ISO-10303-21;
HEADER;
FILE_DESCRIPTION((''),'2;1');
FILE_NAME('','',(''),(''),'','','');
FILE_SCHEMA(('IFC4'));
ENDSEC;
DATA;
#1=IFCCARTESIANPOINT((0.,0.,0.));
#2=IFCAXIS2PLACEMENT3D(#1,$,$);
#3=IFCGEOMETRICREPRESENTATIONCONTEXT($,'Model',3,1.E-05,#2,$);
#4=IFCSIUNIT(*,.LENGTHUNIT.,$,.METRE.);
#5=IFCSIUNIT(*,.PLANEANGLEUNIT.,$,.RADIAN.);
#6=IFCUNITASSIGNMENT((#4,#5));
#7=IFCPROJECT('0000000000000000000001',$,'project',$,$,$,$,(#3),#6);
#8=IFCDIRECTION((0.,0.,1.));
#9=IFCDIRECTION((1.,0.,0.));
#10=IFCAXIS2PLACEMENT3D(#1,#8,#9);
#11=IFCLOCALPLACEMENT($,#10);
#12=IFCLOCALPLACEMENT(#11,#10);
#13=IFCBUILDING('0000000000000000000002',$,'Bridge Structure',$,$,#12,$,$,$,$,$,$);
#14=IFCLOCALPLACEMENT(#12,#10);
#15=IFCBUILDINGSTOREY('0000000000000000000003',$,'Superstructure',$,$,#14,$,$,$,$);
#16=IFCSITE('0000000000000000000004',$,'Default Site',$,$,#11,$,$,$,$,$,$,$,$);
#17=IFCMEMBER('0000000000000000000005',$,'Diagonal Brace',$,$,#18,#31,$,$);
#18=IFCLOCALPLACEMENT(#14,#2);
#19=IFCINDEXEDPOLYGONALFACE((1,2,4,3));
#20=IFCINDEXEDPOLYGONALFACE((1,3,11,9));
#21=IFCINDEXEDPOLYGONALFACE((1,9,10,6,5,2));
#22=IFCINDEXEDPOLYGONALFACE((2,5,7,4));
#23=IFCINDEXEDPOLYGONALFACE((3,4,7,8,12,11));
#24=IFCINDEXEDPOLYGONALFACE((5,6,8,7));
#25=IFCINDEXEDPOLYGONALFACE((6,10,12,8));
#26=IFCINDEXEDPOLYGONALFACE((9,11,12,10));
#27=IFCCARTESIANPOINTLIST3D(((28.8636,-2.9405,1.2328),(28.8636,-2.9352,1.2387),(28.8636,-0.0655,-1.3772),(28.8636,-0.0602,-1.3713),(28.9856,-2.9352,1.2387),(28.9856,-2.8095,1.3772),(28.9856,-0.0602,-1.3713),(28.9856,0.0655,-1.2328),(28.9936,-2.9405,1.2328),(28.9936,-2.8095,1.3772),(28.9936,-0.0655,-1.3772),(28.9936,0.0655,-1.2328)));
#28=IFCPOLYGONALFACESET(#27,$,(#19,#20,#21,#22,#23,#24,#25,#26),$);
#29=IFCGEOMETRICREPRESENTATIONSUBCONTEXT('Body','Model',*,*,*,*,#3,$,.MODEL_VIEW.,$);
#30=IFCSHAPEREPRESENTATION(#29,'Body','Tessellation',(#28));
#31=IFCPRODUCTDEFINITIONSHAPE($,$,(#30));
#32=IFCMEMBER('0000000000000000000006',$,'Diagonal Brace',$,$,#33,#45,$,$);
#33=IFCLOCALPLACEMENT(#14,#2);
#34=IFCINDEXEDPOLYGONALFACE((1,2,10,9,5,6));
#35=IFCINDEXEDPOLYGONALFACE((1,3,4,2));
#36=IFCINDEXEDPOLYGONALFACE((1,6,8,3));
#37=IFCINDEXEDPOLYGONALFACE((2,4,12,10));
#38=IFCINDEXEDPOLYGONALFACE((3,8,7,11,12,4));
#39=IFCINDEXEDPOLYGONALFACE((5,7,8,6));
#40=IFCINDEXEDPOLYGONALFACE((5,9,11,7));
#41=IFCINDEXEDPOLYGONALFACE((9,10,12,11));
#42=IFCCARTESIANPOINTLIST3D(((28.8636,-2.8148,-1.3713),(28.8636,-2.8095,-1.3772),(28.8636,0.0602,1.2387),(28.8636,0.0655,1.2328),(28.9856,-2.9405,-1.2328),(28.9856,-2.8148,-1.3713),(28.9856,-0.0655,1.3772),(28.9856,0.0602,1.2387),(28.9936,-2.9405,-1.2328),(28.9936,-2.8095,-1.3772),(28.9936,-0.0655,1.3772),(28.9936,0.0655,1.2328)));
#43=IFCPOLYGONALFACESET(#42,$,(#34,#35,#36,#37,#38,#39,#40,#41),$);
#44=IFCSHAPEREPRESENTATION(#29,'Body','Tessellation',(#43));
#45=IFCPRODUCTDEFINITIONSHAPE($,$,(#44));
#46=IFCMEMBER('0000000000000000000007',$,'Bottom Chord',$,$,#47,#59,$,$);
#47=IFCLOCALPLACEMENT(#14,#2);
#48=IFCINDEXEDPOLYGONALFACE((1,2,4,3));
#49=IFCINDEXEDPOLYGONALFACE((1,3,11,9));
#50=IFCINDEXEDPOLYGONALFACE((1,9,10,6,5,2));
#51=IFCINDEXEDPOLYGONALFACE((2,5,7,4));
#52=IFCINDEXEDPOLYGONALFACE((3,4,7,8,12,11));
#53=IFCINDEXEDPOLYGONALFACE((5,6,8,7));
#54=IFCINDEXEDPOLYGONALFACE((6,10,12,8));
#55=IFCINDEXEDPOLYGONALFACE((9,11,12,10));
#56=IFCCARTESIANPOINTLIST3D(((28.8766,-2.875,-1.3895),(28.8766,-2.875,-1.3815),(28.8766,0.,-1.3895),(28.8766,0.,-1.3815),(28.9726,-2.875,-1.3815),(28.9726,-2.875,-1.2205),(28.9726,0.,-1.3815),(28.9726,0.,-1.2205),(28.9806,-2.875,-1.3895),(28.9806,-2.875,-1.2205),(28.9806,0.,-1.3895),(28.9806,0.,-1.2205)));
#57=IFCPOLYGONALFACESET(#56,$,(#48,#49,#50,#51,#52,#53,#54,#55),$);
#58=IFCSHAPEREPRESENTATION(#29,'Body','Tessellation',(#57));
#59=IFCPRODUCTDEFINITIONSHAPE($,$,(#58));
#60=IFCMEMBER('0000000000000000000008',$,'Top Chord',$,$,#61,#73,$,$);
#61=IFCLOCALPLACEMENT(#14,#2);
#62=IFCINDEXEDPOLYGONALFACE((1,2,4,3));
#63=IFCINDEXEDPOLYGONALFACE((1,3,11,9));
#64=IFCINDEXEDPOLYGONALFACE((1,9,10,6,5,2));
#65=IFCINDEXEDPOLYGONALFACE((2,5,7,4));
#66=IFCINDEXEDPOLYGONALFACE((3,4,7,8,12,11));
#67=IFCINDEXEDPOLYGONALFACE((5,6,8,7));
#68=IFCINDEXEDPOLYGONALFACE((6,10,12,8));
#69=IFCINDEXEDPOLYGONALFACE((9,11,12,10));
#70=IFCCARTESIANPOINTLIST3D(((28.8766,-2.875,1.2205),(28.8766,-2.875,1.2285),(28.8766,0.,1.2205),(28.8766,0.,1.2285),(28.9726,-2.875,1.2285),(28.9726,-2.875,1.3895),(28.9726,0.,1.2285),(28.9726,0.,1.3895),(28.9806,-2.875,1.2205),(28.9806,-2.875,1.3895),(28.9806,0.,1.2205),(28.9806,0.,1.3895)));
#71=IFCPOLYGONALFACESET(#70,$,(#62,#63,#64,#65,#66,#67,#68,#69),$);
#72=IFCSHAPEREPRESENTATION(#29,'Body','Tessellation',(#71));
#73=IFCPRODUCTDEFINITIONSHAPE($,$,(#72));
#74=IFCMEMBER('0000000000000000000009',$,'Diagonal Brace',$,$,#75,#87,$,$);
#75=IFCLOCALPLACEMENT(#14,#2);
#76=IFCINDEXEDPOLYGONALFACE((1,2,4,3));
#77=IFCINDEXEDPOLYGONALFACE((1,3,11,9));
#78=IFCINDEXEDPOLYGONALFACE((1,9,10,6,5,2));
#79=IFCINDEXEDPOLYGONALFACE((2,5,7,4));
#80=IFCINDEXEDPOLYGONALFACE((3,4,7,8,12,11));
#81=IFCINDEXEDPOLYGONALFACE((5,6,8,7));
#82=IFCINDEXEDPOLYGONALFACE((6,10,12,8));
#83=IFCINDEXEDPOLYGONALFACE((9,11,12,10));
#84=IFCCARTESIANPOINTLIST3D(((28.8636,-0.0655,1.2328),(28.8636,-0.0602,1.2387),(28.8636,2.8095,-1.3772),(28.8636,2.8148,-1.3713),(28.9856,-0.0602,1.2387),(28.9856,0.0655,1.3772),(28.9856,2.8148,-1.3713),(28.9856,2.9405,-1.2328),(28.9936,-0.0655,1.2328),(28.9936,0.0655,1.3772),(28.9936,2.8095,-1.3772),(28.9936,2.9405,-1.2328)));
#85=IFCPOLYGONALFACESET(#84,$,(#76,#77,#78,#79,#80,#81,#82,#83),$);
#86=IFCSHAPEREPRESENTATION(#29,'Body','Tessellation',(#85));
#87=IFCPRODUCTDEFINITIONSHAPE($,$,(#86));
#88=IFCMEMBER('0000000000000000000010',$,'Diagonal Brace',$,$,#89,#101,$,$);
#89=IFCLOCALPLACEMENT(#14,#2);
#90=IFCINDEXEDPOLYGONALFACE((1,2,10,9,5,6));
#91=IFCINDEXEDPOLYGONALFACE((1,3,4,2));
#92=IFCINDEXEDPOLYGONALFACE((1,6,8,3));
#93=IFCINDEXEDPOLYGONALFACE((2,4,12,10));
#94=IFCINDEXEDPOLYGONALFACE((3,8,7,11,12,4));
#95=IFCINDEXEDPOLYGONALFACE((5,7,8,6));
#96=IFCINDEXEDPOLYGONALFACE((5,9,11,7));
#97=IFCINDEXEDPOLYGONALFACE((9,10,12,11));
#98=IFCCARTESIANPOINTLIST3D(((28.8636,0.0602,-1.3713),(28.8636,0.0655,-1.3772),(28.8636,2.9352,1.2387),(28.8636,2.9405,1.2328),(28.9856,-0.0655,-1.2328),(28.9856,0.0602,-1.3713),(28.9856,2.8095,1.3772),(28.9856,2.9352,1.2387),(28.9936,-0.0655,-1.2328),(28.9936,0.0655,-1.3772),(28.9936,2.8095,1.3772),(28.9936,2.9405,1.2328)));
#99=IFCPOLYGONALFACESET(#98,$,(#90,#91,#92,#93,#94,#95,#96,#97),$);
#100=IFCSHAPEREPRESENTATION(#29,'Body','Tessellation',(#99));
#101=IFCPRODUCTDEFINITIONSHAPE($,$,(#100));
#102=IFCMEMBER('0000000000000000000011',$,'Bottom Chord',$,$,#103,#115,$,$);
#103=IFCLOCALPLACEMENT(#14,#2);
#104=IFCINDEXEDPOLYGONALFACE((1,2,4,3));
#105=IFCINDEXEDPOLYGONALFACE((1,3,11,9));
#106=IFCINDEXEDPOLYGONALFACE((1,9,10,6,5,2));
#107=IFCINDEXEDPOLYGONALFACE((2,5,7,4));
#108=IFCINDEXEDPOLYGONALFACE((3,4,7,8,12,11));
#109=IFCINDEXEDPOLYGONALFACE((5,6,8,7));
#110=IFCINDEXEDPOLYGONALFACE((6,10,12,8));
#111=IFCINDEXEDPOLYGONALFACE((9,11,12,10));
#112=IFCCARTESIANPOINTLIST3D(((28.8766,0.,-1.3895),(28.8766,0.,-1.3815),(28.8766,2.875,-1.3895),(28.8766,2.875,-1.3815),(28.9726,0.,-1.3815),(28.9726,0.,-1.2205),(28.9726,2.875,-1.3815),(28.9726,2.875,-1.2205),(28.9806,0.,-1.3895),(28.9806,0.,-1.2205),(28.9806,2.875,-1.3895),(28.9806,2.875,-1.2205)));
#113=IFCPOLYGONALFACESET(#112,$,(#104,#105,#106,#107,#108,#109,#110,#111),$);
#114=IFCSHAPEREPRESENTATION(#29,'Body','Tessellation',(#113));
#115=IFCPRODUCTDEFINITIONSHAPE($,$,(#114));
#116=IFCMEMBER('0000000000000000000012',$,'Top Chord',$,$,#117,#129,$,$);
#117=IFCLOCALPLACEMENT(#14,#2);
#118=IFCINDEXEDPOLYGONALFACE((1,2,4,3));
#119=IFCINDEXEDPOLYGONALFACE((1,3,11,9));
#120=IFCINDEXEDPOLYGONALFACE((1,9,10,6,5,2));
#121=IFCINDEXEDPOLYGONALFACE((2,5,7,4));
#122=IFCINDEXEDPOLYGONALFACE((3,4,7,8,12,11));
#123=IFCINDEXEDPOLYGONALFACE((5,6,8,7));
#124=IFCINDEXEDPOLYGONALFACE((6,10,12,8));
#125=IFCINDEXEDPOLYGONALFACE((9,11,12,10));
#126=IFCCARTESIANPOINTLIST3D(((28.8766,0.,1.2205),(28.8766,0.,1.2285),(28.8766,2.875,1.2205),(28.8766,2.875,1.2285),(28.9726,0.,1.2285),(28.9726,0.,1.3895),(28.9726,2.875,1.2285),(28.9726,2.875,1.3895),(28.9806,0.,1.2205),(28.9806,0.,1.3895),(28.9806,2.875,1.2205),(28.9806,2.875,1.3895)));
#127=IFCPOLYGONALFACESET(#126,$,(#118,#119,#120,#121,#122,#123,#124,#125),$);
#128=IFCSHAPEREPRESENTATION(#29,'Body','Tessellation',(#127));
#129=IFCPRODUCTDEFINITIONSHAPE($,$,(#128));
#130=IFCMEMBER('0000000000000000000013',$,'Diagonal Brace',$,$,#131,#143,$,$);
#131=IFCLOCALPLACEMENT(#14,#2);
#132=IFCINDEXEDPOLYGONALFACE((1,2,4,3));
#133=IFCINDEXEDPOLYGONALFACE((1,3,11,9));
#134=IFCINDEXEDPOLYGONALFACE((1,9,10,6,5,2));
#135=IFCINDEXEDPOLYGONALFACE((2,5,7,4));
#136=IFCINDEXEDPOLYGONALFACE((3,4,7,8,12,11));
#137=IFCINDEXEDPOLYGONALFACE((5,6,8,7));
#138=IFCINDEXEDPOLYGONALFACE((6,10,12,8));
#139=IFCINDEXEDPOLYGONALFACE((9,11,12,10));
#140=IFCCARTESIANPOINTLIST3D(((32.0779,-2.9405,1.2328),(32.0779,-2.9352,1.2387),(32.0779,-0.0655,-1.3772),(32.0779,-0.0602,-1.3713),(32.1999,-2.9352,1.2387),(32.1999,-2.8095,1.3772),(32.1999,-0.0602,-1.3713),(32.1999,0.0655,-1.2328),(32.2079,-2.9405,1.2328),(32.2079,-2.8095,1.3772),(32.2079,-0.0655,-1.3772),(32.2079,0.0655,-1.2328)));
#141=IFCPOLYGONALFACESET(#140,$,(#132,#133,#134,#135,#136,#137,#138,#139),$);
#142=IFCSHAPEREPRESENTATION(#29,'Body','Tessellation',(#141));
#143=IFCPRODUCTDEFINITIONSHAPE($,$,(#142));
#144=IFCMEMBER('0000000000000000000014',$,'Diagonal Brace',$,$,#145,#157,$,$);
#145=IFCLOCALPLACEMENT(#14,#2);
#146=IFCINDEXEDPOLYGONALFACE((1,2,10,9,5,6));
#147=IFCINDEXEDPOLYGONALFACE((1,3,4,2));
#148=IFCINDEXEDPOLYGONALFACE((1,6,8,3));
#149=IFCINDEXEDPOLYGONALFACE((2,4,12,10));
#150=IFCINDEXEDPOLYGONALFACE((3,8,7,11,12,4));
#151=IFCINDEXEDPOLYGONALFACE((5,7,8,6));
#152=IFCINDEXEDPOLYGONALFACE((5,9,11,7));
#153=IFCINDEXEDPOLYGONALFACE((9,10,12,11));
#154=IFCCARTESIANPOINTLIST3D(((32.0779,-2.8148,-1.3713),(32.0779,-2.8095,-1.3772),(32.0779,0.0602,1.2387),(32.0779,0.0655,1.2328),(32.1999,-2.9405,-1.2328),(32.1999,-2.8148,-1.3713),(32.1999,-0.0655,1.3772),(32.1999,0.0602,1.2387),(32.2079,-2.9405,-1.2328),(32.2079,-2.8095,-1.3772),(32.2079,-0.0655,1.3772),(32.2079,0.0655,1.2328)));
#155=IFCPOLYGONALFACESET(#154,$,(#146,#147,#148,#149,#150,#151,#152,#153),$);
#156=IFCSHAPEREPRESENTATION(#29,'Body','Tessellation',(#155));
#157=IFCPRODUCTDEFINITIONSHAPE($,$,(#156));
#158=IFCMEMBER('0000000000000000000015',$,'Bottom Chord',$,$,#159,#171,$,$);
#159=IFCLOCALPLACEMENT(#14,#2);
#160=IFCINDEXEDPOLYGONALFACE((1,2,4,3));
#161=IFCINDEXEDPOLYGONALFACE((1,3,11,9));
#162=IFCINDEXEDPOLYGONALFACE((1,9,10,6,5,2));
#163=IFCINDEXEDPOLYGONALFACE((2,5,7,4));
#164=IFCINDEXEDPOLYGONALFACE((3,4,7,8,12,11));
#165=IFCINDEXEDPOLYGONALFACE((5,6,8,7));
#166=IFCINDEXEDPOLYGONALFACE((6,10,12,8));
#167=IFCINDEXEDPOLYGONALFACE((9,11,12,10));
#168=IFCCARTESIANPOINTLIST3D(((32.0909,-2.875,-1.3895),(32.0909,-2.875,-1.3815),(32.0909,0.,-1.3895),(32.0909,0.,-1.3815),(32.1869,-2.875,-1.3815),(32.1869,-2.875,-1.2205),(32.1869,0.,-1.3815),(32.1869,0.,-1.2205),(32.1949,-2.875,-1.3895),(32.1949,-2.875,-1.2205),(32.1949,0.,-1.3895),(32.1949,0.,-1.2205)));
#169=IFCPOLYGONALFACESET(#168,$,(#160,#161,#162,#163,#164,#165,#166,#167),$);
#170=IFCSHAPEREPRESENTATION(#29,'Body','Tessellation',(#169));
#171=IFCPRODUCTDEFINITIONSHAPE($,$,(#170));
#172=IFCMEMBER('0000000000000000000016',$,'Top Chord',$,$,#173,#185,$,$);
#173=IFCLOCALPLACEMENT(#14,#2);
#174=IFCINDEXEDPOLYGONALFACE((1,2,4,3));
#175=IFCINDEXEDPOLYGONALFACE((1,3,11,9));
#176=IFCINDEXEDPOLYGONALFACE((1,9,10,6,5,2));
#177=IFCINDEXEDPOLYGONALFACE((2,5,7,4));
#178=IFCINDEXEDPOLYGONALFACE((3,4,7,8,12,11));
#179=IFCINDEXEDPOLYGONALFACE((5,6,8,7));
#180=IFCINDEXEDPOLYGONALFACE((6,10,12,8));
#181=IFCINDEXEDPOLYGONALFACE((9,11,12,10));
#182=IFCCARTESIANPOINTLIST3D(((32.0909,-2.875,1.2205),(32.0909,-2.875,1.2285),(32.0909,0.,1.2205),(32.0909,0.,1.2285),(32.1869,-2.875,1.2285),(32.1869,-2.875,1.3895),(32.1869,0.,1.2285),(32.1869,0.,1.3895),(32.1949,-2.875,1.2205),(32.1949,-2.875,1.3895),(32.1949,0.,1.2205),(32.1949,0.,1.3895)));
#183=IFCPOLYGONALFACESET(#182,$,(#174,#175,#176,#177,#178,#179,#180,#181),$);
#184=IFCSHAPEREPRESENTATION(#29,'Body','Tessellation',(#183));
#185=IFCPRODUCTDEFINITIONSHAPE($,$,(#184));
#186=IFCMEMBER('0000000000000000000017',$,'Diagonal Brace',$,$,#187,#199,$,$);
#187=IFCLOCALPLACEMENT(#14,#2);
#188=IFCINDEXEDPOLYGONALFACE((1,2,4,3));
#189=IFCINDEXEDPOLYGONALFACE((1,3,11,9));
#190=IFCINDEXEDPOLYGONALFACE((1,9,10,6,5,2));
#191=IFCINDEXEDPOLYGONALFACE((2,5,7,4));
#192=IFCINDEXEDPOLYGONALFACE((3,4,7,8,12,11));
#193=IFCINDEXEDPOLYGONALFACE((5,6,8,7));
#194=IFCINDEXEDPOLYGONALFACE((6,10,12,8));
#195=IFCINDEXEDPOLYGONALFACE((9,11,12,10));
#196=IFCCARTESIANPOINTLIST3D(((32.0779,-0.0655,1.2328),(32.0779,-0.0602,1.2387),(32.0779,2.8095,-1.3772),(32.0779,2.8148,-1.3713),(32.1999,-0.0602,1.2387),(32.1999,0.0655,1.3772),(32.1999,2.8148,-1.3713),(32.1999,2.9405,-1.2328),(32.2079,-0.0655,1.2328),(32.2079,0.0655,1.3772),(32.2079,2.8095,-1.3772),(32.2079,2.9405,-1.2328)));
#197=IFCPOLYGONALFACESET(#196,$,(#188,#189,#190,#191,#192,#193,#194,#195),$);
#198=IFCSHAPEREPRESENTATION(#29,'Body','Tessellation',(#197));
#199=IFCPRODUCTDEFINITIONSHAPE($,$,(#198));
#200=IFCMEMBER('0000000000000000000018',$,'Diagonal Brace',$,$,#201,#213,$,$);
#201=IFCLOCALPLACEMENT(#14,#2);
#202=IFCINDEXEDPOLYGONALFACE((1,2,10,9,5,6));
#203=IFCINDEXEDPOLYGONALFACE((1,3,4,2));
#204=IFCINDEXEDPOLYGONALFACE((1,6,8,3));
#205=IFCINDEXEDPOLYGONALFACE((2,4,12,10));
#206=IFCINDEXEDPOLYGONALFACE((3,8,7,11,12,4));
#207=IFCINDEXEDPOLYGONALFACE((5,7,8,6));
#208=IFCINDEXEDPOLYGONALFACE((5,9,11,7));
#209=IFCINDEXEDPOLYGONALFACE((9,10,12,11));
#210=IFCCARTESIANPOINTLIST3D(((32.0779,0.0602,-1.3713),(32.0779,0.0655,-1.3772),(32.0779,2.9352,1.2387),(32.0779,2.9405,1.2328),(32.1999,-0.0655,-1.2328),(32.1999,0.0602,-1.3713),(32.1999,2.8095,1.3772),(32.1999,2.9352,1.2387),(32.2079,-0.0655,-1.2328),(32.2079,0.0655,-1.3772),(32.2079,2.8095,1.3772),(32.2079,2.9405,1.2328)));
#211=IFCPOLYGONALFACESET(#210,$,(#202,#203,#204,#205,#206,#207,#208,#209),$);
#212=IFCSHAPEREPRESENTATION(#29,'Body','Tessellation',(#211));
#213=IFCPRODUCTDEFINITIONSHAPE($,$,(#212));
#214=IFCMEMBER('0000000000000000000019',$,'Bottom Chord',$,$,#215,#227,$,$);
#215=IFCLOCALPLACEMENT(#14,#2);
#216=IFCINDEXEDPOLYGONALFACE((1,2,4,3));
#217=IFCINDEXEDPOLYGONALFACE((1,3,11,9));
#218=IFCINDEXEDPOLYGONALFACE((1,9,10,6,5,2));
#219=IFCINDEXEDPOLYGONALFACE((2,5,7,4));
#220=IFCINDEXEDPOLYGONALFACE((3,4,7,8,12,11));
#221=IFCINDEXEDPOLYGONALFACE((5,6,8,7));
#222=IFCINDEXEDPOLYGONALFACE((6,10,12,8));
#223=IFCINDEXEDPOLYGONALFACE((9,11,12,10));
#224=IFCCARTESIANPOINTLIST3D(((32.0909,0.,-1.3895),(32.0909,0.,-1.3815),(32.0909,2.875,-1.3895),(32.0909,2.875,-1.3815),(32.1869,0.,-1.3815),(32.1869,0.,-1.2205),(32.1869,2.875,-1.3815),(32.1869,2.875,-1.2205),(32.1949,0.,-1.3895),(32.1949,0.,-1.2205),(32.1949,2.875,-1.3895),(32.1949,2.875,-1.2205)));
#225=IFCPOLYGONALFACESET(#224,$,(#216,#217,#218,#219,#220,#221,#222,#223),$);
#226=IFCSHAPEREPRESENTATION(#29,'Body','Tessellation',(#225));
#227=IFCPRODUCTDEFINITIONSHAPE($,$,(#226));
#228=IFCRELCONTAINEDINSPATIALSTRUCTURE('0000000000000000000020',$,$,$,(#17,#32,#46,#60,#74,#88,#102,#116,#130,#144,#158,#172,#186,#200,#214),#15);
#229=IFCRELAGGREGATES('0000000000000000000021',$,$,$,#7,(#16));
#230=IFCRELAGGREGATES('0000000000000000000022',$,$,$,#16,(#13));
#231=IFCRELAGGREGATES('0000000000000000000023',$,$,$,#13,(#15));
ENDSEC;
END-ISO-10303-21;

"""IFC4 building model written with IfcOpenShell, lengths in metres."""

from ifc_helpers import new_model, si_unit, frame, origin, origin_with_axes, origin_2d_with_axis, place, context, subcontext, project, spatial, l_section, extrude, element, save


model = new_model("IFC4")

# Units and contexts
model_context = context("Model", 3, precision=1e-05, world=origin())
body_context = subcontext(model_context, "Body", "Model", "MODEL_VIEW")
ifc_project = project(units=[si_unit("LENGTHUNIT", "METRE"), si_unit("PLANEANGLEUNIT", "RADIAN")], contexts=[model_context])

# Site, building, storey
site_placement = place(None, origin_with_axes())
site = spatial("IfcSite", under=ifc_project, at=site_placement, Name="Default Site")
building_placement = place(site_placement, origin_with_axes())
building = spatial("IfcBuilding", under=site, at=building_placement, Name="Bridge Structure")
storey_placement = place(building_placement, origin_with_axes())
storey = spatial("IfcBuildingStorey", under=building, at=storey_placement, Name="Superstructure")

# Members
for number, where, z_axis, x_axis, name in (
    (1, (28.9286, -2.875, 1.305), (0.0, 0.740406, -0.67216), (-1.0, 0.0, 0.0), "Diagonal Brace"),
    (2, (28.9286, -2.875, -1.305), (0.0, 0.740406, 0.67216), (-1.0, 0.0, 0.0), "Diagonal Brace"),
):
    element("IfcMember", number, at=place(storey_placement, frame(where, z_axis=z_axis, x_axis=x_axis)), inside=storey, Name=name, context=body_context, shape_type="SweptSolid", body=[
        extrude(l_section(Depth=0.195, Width=0.13, Thickness=0.008, at=origin_2d_with_axis()), origin_with_axes(), (0.0, 0.0, 1.0), 3.883),
    ])
for number, where, z_axis, x_axis, name in (
    (3, (28.9286, -2.875, -1.305), (0.0, 1.0, 0.0), (-1.0, 0.0, 0.0), "Bottom Chord"),
    (4, (28.9286, -2.875, 1.305), (0.0, 1.0, 0.0), (-1.0, 0.0, 0.0), "Top Chord"),
):
    element("IfcMember", number, at=place(storey_placement, frame(where, z_axis=z_axis, x_axis=x_axis)), inside=storey, Name=name, context=body_context, shape_type="SweptSolid", body=[
        extrude(l_section(Depth=0.169, Width=0.104, Thickness=0.008, at=origin_2d_with_axis()), origin_with_axes(), (0.0, 0.0, 1.0), 2.875),
    ])
for number, where, z_axis, x_axis, name in (
    (5, (28.9286, 0.0, 1.305), (0.0, 0.740406, -0.67216), (-1.0, 0.0, 0.0), "Diagonal Brace"),
    (6, (28.9286, 0.0, -1.305), (0.0, 0.740406, 0.67216), (-1.0, 0.0, 0.0), "Diagonal Brace"),
):
    element("IfcMember", number, at=place(storey_placement, frame(where, z_axis=z_axis, x_axis=x_axis)), inside=storey, Name=name, context=body_context, shape_type="SweptSolid", body=[
        extrude(l_section(Depth=0.195, Width=0.13, Thickness=0.008, at=origin_2d_with_axis()), origin_with_axes(), (0.0, 0.0, 1.0), 3.883),
    ])
for number, where, z_axis, x_axis, name in (
    (7, (28.9286, 0.0, -1.305), (0.0, 1.0, 0.0), (-1.0, 0.0, 0.0), "Bottom Chord"),
    (8, (28.9286, 0.0, 1.305), (0.0, 1.0, 0.0), (-1.0, 0.0, 0.0), "Top Chord"),
):
    element("IfcMember", number, at=place(storey_placement, frame(where, z_axis=z_axis, x_axis=x_axis)), inside=storey, Name=name, context=body_context, shape_type="SweptSolid", body=[
        extrude(l_section(Depth=0.169, Width=0.104, Thickness=0.008, at=origin_2d_with_axis()), origin_with_axes(), (0.0, 0.0, 1.0), 2.875),
    ])
for number, where, z_axis, x_axis, name in (
    (9, (32.1429, -2.875, 1.305), (0.0, 0.740406, -0.67216), (-1.0, 0.0, 0.0), "Diagonal Brace"),
    (10, (32.1429, -2.875, -1.305), (0.0, 0.740406, 0.67216), (-1.0, 0.0, 0.0), "Diagonal Brace"),
):
    element("IfcMember", number, at=place(storey_placement, frame(where, z_axis=z_axis, x_axis=x_axis)), inside=storey, Name=name, context=body_context, shape_type="SweptSolid", body=[
        extrude(l_section(Depth=0.195, Width=0.13, Thickness=0.008, at=origin_2d_with_axis()), origin_with_axes(), (0.0, 0.0, 1.0), 3.883),
    ])
for number, where, z_axis, x_axis, name in (
    (11, (32.1429, -2.875, -1.305), (0.0, 1.0, 0.0), (-1.0, 0.0, 0.0), "Bottom Chord"),
    (12, (32.1429, -2.875, 1.305), (0.0, 1.0, 0.0), (-1.0, 0.0, 0.0), "Top Chord"),
):
    element("IfcMember", number, at=place(storey_placement, frame(where, z_axis=z_axis, x_axis=x_axis)), inside=storey, Name=name, context=body_context, shape_type="SweptSolid", body=[
        extrude(l_section(Depth=0.169, Width=0.104, Thickness=0.008, at=origin_2d_with_axis()), origin_with_axes(), (0.0, 0.0, 1.0), 2.875),
    ])
for number, where, z_axis, x_axis, name in (
    (13, (32.1429, 0.0, 1.305), (0.0, 0.740406, -0.67216), (-1.0, 0.0, 0.0), "Diagonal Brace"),
    (14, (32.1429, 0.0, -1.305), (0.0, 0.740406, 0.67216), (-1.0, 0.0, 0.0), "Diagonal Brace"),
):
    element("IfcMember", number, at=place(storey_placement, frame(where, z_axis=z_axis, x_axis=x_axis)), inside=storey, Name=name, context=body_context, shape_type="SweptSolid", body=[
        extrude(l_section(Depth=0.195, Width=0.13, Thickness=0.008, at=origin_2d_with_axis()), origin_with_axes(), (0.0, 0.0, 1.0), 3.883),
    ])
for number, where, z_axis, x_axis, name in (
    (15, (32.1429, 0.0, -1.305), (0.0, 1.0, 0.0), (-1.0, 0.0, 0.0), "Bottom Chord"),
):
    element("IfcMember", number, at=place(storey_placement, frame(where, z_axis=z_axis, x_axis=x_axis)), inside=storey, Name=name, context=body_context, shape_type="SweptSolid", body=[
        extrude(l_section(Depth=0.169, Width=0.104, Thickness=0.008, at=origin_2d_with_axis()), origin_with_axes(), (0.0, 0.0, 1.0), 2.875),
    ])

save(model, "model.ifc")
